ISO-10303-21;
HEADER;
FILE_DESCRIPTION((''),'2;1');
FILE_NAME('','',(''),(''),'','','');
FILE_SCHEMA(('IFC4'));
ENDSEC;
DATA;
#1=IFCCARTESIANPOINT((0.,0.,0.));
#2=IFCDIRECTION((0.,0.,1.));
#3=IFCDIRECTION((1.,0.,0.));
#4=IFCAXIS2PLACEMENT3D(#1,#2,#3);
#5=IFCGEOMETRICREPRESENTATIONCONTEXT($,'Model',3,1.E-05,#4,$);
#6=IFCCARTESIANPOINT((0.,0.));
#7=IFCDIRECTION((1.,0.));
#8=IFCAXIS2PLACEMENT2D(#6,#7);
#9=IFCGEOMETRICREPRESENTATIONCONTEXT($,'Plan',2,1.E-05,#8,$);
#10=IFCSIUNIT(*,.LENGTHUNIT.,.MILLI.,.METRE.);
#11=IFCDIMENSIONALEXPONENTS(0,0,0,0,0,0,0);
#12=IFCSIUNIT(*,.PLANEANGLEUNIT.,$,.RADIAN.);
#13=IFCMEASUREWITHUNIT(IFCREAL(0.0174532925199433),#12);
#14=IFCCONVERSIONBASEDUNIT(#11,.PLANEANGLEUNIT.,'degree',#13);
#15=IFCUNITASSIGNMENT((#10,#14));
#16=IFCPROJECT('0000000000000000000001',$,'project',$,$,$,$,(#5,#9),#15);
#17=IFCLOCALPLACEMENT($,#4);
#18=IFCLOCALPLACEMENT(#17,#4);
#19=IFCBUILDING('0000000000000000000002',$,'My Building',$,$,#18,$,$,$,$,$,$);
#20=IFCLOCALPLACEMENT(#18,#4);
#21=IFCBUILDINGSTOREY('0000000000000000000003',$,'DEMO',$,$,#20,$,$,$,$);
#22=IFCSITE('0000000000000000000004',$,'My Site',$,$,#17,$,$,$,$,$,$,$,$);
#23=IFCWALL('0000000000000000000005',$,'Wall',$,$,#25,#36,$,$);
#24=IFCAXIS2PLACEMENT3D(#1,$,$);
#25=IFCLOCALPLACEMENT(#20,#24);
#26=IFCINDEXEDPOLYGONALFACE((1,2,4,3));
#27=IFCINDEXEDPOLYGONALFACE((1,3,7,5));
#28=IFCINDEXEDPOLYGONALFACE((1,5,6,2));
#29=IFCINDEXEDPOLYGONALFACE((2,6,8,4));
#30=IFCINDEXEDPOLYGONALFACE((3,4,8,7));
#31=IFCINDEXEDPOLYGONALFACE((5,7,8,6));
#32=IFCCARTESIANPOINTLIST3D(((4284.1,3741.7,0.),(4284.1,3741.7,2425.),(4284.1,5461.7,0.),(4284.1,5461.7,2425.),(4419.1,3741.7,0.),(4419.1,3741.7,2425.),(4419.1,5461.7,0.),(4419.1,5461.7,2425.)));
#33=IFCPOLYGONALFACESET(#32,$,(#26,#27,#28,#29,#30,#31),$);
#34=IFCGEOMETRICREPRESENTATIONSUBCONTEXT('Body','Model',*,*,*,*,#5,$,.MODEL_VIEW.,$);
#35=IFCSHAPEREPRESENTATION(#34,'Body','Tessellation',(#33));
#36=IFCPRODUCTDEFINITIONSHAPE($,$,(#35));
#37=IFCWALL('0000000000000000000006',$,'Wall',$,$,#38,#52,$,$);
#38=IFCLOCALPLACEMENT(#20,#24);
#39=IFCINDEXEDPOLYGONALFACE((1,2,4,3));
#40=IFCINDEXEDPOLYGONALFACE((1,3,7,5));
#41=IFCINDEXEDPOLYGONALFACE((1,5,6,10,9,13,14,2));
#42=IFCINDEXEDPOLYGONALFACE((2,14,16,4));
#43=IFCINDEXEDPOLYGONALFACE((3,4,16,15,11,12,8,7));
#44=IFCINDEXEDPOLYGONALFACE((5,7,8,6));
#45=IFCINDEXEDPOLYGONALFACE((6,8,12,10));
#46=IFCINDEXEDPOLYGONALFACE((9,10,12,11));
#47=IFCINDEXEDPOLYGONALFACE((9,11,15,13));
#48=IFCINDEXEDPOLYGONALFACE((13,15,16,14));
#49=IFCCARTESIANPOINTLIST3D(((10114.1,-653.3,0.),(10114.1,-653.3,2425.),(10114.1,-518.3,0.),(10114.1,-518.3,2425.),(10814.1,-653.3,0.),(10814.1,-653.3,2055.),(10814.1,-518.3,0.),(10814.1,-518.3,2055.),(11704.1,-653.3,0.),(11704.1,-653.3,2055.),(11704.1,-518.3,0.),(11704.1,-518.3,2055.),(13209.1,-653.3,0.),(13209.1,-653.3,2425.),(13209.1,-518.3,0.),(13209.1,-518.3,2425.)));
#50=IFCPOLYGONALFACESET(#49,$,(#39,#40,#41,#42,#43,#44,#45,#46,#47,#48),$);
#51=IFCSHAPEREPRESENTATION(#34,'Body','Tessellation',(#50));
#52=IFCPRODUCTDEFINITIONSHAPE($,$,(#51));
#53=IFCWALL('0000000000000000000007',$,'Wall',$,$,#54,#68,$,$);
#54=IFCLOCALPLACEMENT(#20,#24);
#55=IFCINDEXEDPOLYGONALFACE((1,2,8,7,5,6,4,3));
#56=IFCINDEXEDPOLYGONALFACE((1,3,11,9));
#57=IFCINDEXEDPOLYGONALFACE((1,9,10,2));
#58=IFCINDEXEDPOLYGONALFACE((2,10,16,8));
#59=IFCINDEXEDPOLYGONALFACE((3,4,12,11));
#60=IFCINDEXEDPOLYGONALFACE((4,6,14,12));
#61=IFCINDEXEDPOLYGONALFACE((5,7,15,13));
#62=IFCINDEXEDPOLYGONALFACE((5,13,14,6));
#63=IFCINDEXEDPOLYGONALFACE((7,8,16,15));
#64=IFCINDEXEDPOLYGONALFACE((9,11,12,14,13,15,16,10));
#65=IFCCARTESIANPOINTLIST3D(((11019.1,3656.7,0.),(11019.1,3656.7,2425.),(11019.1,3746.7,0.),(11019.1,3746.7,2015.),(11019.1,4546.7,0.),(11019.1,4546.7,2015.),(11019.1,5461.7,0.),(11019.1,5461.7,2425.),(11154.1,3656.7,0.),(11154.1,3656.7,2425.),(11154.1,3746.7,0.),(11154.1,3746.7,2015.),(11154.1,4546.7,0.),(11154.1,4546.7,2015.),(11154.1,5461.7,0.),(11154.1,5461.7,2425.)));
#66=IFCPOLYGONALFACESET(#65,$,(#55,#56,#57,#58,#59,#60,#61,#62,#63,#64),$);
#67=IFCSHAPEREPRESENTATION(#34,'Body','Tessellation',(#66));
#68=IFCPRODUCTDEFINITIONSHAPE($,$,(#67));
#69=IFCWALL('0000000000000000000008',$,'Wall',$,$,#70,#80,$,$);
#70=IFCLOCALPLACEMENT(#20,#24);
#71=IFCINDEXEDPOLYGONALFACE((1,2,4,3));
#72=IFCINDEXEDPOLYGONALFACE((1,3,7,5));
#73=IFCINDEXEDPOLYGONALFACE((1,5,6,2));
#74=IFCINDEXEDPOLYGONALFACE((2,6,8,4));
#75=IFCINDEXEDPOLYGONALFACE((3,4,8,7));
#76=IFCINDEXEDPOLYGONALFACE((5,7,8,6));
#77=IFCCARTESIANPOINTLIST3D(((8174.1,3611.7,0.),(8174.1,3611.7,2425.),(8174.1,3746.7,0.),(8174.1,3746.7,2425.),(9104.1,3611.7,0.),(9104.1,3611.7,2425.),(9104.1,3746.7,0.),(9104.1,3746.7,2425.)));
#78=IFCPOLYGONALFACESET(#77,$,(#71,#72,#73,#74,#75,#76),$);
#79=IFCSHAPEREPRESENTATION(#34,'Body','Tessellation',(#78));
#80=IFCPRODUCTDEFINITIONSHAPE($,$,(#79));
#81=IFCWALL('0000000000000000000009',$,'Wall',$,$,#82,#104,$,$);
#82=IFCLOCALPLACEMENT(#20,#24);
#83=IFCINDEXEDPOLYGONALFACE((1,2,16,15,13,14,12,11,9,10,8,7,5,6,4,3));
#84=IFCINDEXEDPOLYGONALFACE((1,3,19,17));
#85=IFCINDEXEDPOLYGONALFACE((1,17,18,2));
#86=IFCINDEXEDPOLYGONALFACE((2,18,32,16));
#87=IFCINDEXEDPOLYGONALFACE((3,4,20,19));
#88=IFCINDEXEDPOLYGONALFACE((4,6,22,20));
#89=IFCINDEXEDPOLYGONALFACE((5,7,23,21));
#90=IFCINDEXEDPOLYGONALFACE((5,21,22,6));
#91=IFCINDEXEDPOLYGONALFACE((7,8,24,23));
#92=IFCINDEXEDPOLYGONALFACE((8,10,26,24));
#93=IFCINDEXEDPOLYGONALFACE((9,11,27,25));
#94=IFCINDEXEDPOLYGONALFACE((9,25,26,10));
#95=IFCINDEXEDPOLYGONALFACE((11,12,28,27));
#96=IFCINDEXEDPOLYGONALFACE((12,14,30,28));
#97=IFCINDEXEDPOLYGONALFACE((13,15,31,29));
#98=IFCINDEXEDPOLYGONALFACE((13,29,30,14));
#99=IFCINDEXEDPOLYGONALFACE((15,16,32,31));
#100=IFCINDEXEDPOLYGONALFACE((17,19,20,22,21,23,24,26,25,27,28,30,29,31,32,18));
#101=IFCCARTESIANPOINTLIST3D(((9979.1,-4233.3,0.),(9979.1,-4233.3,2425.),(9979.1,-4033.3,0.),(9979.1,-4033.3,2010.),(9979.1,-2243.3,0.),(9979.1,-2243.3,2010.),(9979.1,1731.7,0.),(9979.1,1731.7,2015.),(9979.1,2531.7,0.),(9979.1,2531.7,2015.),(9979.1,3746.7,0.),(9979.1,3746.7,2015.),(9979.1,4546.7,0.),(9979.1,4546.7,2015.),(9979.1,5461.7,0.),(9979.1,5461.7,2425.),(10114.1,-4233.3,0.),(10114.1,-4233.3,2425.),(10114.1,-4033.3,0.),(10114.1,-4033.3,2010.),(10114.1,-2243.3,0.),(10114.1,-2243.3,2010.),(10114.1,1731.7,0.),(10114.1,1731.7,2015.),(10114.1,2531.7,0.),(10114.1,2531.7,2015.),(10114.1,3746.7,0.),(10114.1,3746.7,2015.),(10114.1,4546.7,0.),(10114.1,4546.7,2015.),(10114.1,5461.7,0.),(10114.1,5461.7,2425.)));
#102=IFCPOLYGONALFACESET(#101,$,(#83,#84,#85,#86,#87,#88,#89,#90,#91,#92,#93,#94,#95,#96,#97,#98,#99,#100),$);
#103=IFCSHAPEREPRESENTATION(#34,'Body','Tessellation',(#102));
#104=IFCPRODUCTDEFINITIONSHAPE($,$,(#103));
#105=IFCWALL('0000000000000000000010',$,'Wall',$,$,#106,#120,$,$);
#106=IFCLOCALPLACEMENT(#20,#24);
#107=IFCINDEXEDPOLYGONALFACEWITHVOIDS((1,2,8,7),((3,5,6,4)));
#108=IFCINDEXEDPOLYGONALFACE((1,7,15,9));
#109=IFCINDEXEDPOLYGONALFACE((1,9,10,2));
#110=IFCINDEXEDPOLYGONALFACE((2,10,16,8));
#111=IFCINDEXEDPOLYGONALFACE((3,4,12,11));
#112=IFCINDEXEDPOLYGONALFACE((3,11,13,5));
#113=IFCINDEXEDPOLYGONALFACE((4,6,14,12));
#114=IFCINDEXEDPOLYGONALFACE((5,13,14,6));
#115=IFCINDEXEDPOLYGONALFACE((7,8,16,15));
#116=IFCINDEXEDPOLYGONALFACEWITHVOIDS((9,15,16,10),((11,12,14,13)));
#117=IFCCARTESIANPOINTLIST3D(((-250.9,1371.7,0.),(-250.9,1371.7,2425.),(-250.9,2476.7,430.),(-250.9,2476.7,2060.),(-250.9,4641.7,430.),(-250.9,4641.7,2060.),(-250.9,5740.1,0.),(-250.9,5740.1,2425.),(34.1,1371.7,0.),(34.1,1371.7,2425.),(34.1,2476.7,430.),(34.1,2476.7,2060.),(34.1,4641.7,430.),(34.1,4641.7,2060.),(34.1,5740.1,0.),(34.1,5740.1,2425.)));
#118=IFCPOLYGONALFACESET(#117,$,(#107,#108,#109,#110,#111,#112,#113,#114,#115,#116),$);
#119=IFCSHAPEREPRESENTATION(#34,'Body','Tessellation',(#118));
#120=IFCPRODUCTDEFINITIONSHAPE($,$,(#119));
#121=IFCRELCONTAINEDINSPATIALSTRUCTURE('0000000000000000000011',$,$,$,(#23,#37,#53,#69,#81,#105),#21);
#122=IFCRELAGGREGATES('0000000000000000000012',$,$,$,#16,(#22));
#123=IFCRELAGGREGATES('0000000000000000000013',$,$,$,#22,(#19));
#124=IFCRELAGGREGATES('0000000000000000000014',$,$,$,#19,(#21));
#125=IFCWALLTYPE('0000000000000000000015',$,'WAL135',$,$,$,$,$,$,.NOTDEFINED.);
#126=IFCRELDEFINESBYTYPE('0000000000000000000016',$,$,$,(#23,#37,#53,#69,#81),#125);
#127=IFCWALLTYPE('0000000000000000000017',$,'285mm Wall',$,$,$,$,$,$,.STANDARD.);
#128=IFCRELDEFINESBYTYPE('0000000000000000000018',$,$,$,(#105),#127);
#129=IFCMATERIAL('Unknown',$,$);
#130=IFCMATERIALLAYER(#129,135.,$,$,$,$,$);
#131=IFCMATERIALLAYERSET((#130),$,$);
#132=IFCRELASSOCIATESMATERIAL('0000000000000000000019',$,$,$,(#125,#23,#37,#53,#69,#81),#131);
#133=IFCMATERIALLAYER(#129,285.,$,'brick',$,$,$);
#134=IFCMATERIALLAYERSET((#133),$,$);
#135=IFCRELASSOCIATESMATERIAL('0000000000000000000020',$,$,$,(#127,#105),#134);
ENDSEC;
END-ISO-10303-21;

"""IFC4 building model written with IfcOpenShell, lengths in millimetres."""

from ifc_helpers import new_model, entity, si_unit, converted_unit, frame, origin_with_axes, origin_2d_with_axis, place, context, subcontext, project, spatial, line, indexed_curve, outline, extrude, source, transform, mapped, material, layer, layer_set, layer_usage, type_object, element, save


model = new_model("IFC4")

# Units and contexts
model_context = context("Model", 3, precision=1e-05, world=origin_with_axes())
plan_context = context("Plan", 2, precision=1e-05, world=origin_2d_with_axis())
body_context = subcontext(model_context, "Body", "Model", "MODEL_VIEW")
ifc_project = project(units=[si_unit("LENGTHUNIT", "METRE", prefix="MILLI"), converted_unit("PLANEANGLEUNIT", "degree", entity("IfcReal", 0.0174532925199433), si_unit("PLANEANGLEUNIT", "RADIAN"), dimensions=[0, 0, 0, 0, 0, 0, 0])], contexts=[model_context, plan_context])

# Site, building, storey
site_placement = place(None, origin_with_axes())
site = spatial("IfcSite", under=ifc_project, at=site_placement, Name="My Site")
building_placement = place(site_placement, origin_with_axes())
building = spatial("IfcBuilding", under=site, at=building_placement, Name="My Building")
storey_placement = place(building_placement, origin_with_axes())
storey = spatial("IfcBuildingStorey", under=building, at=storey_placement, Name="DEMO")

# Wall
ifc_material = material(Name="Unknown")
ifc_layer_1 = layer(ifc_material, 135.0)
ifc_layer_set_1 = layer_set([ifc_layer_1])
ifc_layer_usage_1 = layer_usage(ifc_layer_set_1, "AXIS2", "POSITIVE", 0.0)
wall_type_1 = type_object("IfcWallType", Name="WAL135", PredefinedType="NOTDEFINED", material=ifc_layer_set_1)
wall_1_placement = place(storey_placement, frame((4284.1, 5461.7, 0.0), z_axis=(0.0, 0.0, 1.0), x_axis=(0.0, -1.0, 0.0)))
element("IfcWall", 1, at=wall_1_placement, inside=storey, type_object=wall_type_1, material=ifc_layer_usage_1, Name="Wall", context=body_context, shape_type="SweptSolid", body=[
    extrude(outline(indexed_curve([(0.0, 0.0), (0.0, 135.0), (1720.0, 135.0), (1720.0, 0.0), (0.0, 0.0)], self_intersect=False)), origin_with_axes(), (0.0, 0.0, 1.0), 2425.0),
])

# Walls, openings
ifc_layer_usage_2 = layer_usage(ifc_layer_set_1, "AXIS2", "POSITIVE", 0.0)
wall_2_placement = place(storey_placement, frame((10114.1, -653.3, 0.0), z_axis=(0.0, 0.0, 1.0), x_axis=(1.0, 0.0, 0.0)))
wall_2 = element("IfcWall", 2, at=wall_2_placement, inside=storey, type_object=wall_type_1, material=ifc_layer_usage_2, Name="Wall", context=body_context, shape_type="SweptSolid", body=[
    extrude(outline(indexed_curve([(0.0, 0.0), (0.0, 135.0), (3095.0, 135.0), (3095.0, 0.0), (0.0, 0.0)], self_intersect=False)), origin_with_axes(), (0.0, 0.0, 1.0), 2425.0),
])
shared_shape_1 = source(origin_with_axes(), body_context, "Body", "SweptSolid", [
    extrude(outline(indexed_curve([(0.0, 0.0), (890.0, 0.0), (890.0, 2055.0), (0.0, 2055.0)], segments=[line(1, 2, 3, 4, 1)])), frame((0.0, -600.0, 0.0), z_axis=(0.0, -1.0, 0.0), x_axis=(1.0, 0.0, 0.0)), (0.0, 0.0, -1.0), 1200.0),
])
opening_1_placement = place(wall_2_placement, frame((700.0, 63.0, 0.0), z_axis=(0.0, 0.0, 1.0), x_axis=(1.0, 0.0, 0.0)))
element("IfcOpeningElement", 3, at=opening_1_placement, cuts=wall_2, PredefinedType="OPENING", context=body_context, shape_type="MappedRepresentation", body=[
    mapped(shared_shape_1, transform((0.0, 0.0, 0.0), x_axis=(1.0, 0.0, 0.0), y_axis=(0.0, 1.0, 0.0), z_axis=(0.0, 0.0, 1.0), scale=1.0)),
])
ifc_layer_usage_3 = layer_usage(ifc_layer_set_1, "AXIS2", "POSITIVE", 0.0)
wall_3_placement = place(storey_placement, frame((11019.1, 5461.7, 0.0), z_axis=(0.0, 0.0, 1.0), x_axis=(0.0, -1.0, 0.0)))
wall_3 = element("IfcWall", 4, at=wall_3_placement, inside=storey, type_object=wall_type_1, material=ifc_layer_usage_3, Name="Wall", context=body_context, shape_type="SweptSolid", body=[
    extrude(outline(indexed_curve([(0.0, 0.0), (0.0, 135.0), (1805.0, 135.0), (1805.0, 0.0), (0.0, 0.0)], self_intersect=False)), origin_with_axes(), (0.0, 0.0, 1.0), 2425.0),
])
shared_shape_2 = source(origin_with_axes(), body_context, "Body", "SweptSolid", [
    extrude(outline(indexed_curve([(0.0, 0.0), (800.0, 0.0), (800.0, 2015.0), (0.0, 2015.0)], segments=[line(1, 2, 3, 4, 1)])), frame((0.0, -600.0, 0.0), z_axis=(0.0, -1.0, 0.0), x_axis=(1.0, 0.0, 0.0)), (0.0, 0.0, -1.0), 1200.0),
])
opening_2_placement = place(wall_3_placement, frame((915.0, 0.0, 0.0), z_axis=(0.0, 0.0, 1.0), x_axis=(1.0, 0.0, 0.0)))
element("IfcOpeningElement", 5, at=opening_2_placement, cuts=wall_3, PredefinedType="OPENING", context=body_context, shape_type="MappedRepresentation", body=[
    mapped(shared_shape_2, transform((0.0, 0.0, 0.0), x_axis=(1.0, 0.0, 0.0), y_axis=(0.0, 1.0, 0.0), z_axis=(0.0, 0.0, 1.0), scale=1.0)),
])

# Wall
ifc_layer_usage_4 = layer_usage(ifc_layer_set_1, "AXIS2", "POSITIVE", 0.0)
wall_4_placement = place(storey_placement, frame((8174.1, 3611.7, 0.0), z_axis=(0.0, 0.0, 1.0), x_axis=(1.0, 0.0, 0.0)))
element("IfcWall", 6, at=wall_4_placement, inside=storey, type_object=wall_type_1, material=ifc_layer_usage_4, Name="Wall", context=body_context, shape_type="SweptSolid", body=[
    extrude(outline(indexed_curve([(0.0, 0.0), (0.0, 135.0), (930.0, 135.0), (930.0, 0.0), (0.0, 0.0)], self_intersect=False)), origin_with_axes(), (0.0, 0.0, 1.0), 2425.0),
])

# Wall, openings
ifc_layer_usage_5 = layer_usage(ifc_layer_set_1, "AXIS2", "POSITIVE", 0.0)
wall_5_placement = place(storey_placement, frame((9979.1, 5461.7, 0.0), z_axis=(0.0, 0.0, 1.0), x_axis=(0.0, -1.0, 0.0)))
wall_5 = element("IfcWall", 7, at=wall_5_placement, inside=storey, type_object=wall_type_1, material=ifc_layer_usage_5, Name="Wall", context=body_context, shape_type="SweptSolid", body=[
    extrude(outline(indexed_curve([(0.0, 0.0), (0.0, 135.0), (9695.0, 135.0), (9695.0, 0.0), (0.0, 0.0)], self_intersect=False)), origin_with_axes(), (0.0, 0.0, 1.0), 2425.0),
])
opening_3_placement = place(wall_5_placement, frame((2930.0, 78.8, 0.0), z_axis=(0.0, 0.0, 1.0), x_axis=(1.0, 0.0, 0.0)))
element("IfcOpeningElement", 8, at=opening_3_placement, cuts=wall_5, PredefinedType="OPENING", context=body_context, shape_type="MappedRepresentation", body=[
    mapped(shared_shape_2, transform((0.0, 0.0, 0.0), x_axis=(1.0, 0.0, 0.0), y_axis=(0.0, 1.0, 0.0), z_axis=(0.0, 0.0, 1.0), scale=1.0)),
])
opening_4_placement = place(wall_5_placement, frame((915.0, 0.0, 0.0), z_axis=(0.0, 0.0, 1.0), x_axis=(1.0, 0.0, 0.0)))
element("IfcOpeningElement", 9, at=opening_4_placement, cuts=wall_5, PredefinedType="OPENING", context=body_context, shape_type="MappedRepresentation", body=[
    mapped(shared_shape_2, transform((0.0, 0.0, 0.0), x_axis=(1.0, 0.0, 0.0), y_axis=(0.0, 1.0, 0.0), z_axis=(0.0, 0.0, 1.0), scale=1.0)),
])
shared_shape_3 = source(origin_with_axes(), body_context, "Body", "SweptSolid", [
    extrude(outline(indexed_curve([(0.0, 0.0), (1790.0, 0.0), (1790.0, 2010.0), (0.0, 2010.0)], segments=[line(1, 2, 3, 4, 1)])), frame((0.0, -600.0, 0.0), z_axis=(0.0, -1.0, 0.0), x_axis=(1.0, 0.0, 0.0)), (0.0, 0.0, -1.0), 1200.0),
])
opening_5_placement = place(wall_5_placement, frame((7705.0, 100.0, 0.0), z_axis=(0.0, 0.0, 1.0), x_axis=(1.0, 0.0, 0.0)))
element("IfcOpeningElement", 10, at=opening_5_placement, cuts=wall_5, PredefinedType="OPENING", context=body_context, shape_type="MappedRepresentation", body=[
    mapped(shared_shape_3, transform((0.0, 0.0, 0.0), x_axis=(1.0, 0.0, 0.0), y_axis=(0.0, 1.0, 0.0), z_axis=(0.0, 0.0, 1.0), scale=1.0)),
])

# Wall, opening
ifc_layer_2 = layer(ifc_material, 285.0, Name="brick")
ifc_layer_set_2 = layer_set([ifc_layer_2])
ifc_layer_usage_6 = layer_usage(ifc_layer_set_2, "AXIS2", "POSITIVE", 0.0)
wall_type_2 = type_object("IfcWallType", Name="285mm Wall", PredefinedType="STANDARD", material=ifc_layer_set_2)
wall_6_placement = place(storey_placement, frame((34.1, 1371.7, 0.0), z_axis=(0.0, 0.0, 1.0), x_axis=(0.0, 1.0, 0.0)))
wall_6 = element("IfcWall", 11, at=wall_6_placement, inside=storey, type_object=wall_type_2, material=ifc_layer_usage_6, Name="Wall", context=body_context, shape_type="SweptSolid", body=[
    extrude(outline(indexed_curve([(0.0, 0.0), (0.0, 285.0), (4368.4, 285.0), (4368.4, 0.0), (0.0, 0.0)], self_intersect=False)), origin_with_axes(), (0.0, 0.0, 1.0), 2425.0),
])
shared_shape_4 = source(origin_with_axes(), body_context, "Body", "SweptSolid", [
    extrude(outline(indexed_curve([(0.0, 0.0), (2165.0, 0.0), (2165.0, 1630.0), (0.0, 1630.0)], segments=[line(1, 2, 3, 4, 1)])), frame((0.0, -600.0, 0.0), z_axis=(0.0, -1.0, 0.0), x_axis=(1.0, 0.0, 0.0)), (0.0, 0.0, -1.0), 1200.0),
])
opening_6_placement = place(wall_6_placement, frame((1105.0, 0.0, 430.0), z_axis=(0.0, 0.0, 1.0), x_axis=(1.0, 0.0, 0.0)))
element("IfcOpeningElement", 12, at=opening_6_placement, cuts=wall_6, PredefinedType="OPENING", context=body_context, shape_type="MappedRepresentation", body=[
    mapped(shared_shape_4, transform((0.0, 0.0, 0.0), x_axis=(1.0, 0.0, 0.0), y_axis=(0.0, 1.0, 0.0), z_axis=(0.0, 0.0, 1.0), scale=1.0)),
])

save(model, "model.ifc")
